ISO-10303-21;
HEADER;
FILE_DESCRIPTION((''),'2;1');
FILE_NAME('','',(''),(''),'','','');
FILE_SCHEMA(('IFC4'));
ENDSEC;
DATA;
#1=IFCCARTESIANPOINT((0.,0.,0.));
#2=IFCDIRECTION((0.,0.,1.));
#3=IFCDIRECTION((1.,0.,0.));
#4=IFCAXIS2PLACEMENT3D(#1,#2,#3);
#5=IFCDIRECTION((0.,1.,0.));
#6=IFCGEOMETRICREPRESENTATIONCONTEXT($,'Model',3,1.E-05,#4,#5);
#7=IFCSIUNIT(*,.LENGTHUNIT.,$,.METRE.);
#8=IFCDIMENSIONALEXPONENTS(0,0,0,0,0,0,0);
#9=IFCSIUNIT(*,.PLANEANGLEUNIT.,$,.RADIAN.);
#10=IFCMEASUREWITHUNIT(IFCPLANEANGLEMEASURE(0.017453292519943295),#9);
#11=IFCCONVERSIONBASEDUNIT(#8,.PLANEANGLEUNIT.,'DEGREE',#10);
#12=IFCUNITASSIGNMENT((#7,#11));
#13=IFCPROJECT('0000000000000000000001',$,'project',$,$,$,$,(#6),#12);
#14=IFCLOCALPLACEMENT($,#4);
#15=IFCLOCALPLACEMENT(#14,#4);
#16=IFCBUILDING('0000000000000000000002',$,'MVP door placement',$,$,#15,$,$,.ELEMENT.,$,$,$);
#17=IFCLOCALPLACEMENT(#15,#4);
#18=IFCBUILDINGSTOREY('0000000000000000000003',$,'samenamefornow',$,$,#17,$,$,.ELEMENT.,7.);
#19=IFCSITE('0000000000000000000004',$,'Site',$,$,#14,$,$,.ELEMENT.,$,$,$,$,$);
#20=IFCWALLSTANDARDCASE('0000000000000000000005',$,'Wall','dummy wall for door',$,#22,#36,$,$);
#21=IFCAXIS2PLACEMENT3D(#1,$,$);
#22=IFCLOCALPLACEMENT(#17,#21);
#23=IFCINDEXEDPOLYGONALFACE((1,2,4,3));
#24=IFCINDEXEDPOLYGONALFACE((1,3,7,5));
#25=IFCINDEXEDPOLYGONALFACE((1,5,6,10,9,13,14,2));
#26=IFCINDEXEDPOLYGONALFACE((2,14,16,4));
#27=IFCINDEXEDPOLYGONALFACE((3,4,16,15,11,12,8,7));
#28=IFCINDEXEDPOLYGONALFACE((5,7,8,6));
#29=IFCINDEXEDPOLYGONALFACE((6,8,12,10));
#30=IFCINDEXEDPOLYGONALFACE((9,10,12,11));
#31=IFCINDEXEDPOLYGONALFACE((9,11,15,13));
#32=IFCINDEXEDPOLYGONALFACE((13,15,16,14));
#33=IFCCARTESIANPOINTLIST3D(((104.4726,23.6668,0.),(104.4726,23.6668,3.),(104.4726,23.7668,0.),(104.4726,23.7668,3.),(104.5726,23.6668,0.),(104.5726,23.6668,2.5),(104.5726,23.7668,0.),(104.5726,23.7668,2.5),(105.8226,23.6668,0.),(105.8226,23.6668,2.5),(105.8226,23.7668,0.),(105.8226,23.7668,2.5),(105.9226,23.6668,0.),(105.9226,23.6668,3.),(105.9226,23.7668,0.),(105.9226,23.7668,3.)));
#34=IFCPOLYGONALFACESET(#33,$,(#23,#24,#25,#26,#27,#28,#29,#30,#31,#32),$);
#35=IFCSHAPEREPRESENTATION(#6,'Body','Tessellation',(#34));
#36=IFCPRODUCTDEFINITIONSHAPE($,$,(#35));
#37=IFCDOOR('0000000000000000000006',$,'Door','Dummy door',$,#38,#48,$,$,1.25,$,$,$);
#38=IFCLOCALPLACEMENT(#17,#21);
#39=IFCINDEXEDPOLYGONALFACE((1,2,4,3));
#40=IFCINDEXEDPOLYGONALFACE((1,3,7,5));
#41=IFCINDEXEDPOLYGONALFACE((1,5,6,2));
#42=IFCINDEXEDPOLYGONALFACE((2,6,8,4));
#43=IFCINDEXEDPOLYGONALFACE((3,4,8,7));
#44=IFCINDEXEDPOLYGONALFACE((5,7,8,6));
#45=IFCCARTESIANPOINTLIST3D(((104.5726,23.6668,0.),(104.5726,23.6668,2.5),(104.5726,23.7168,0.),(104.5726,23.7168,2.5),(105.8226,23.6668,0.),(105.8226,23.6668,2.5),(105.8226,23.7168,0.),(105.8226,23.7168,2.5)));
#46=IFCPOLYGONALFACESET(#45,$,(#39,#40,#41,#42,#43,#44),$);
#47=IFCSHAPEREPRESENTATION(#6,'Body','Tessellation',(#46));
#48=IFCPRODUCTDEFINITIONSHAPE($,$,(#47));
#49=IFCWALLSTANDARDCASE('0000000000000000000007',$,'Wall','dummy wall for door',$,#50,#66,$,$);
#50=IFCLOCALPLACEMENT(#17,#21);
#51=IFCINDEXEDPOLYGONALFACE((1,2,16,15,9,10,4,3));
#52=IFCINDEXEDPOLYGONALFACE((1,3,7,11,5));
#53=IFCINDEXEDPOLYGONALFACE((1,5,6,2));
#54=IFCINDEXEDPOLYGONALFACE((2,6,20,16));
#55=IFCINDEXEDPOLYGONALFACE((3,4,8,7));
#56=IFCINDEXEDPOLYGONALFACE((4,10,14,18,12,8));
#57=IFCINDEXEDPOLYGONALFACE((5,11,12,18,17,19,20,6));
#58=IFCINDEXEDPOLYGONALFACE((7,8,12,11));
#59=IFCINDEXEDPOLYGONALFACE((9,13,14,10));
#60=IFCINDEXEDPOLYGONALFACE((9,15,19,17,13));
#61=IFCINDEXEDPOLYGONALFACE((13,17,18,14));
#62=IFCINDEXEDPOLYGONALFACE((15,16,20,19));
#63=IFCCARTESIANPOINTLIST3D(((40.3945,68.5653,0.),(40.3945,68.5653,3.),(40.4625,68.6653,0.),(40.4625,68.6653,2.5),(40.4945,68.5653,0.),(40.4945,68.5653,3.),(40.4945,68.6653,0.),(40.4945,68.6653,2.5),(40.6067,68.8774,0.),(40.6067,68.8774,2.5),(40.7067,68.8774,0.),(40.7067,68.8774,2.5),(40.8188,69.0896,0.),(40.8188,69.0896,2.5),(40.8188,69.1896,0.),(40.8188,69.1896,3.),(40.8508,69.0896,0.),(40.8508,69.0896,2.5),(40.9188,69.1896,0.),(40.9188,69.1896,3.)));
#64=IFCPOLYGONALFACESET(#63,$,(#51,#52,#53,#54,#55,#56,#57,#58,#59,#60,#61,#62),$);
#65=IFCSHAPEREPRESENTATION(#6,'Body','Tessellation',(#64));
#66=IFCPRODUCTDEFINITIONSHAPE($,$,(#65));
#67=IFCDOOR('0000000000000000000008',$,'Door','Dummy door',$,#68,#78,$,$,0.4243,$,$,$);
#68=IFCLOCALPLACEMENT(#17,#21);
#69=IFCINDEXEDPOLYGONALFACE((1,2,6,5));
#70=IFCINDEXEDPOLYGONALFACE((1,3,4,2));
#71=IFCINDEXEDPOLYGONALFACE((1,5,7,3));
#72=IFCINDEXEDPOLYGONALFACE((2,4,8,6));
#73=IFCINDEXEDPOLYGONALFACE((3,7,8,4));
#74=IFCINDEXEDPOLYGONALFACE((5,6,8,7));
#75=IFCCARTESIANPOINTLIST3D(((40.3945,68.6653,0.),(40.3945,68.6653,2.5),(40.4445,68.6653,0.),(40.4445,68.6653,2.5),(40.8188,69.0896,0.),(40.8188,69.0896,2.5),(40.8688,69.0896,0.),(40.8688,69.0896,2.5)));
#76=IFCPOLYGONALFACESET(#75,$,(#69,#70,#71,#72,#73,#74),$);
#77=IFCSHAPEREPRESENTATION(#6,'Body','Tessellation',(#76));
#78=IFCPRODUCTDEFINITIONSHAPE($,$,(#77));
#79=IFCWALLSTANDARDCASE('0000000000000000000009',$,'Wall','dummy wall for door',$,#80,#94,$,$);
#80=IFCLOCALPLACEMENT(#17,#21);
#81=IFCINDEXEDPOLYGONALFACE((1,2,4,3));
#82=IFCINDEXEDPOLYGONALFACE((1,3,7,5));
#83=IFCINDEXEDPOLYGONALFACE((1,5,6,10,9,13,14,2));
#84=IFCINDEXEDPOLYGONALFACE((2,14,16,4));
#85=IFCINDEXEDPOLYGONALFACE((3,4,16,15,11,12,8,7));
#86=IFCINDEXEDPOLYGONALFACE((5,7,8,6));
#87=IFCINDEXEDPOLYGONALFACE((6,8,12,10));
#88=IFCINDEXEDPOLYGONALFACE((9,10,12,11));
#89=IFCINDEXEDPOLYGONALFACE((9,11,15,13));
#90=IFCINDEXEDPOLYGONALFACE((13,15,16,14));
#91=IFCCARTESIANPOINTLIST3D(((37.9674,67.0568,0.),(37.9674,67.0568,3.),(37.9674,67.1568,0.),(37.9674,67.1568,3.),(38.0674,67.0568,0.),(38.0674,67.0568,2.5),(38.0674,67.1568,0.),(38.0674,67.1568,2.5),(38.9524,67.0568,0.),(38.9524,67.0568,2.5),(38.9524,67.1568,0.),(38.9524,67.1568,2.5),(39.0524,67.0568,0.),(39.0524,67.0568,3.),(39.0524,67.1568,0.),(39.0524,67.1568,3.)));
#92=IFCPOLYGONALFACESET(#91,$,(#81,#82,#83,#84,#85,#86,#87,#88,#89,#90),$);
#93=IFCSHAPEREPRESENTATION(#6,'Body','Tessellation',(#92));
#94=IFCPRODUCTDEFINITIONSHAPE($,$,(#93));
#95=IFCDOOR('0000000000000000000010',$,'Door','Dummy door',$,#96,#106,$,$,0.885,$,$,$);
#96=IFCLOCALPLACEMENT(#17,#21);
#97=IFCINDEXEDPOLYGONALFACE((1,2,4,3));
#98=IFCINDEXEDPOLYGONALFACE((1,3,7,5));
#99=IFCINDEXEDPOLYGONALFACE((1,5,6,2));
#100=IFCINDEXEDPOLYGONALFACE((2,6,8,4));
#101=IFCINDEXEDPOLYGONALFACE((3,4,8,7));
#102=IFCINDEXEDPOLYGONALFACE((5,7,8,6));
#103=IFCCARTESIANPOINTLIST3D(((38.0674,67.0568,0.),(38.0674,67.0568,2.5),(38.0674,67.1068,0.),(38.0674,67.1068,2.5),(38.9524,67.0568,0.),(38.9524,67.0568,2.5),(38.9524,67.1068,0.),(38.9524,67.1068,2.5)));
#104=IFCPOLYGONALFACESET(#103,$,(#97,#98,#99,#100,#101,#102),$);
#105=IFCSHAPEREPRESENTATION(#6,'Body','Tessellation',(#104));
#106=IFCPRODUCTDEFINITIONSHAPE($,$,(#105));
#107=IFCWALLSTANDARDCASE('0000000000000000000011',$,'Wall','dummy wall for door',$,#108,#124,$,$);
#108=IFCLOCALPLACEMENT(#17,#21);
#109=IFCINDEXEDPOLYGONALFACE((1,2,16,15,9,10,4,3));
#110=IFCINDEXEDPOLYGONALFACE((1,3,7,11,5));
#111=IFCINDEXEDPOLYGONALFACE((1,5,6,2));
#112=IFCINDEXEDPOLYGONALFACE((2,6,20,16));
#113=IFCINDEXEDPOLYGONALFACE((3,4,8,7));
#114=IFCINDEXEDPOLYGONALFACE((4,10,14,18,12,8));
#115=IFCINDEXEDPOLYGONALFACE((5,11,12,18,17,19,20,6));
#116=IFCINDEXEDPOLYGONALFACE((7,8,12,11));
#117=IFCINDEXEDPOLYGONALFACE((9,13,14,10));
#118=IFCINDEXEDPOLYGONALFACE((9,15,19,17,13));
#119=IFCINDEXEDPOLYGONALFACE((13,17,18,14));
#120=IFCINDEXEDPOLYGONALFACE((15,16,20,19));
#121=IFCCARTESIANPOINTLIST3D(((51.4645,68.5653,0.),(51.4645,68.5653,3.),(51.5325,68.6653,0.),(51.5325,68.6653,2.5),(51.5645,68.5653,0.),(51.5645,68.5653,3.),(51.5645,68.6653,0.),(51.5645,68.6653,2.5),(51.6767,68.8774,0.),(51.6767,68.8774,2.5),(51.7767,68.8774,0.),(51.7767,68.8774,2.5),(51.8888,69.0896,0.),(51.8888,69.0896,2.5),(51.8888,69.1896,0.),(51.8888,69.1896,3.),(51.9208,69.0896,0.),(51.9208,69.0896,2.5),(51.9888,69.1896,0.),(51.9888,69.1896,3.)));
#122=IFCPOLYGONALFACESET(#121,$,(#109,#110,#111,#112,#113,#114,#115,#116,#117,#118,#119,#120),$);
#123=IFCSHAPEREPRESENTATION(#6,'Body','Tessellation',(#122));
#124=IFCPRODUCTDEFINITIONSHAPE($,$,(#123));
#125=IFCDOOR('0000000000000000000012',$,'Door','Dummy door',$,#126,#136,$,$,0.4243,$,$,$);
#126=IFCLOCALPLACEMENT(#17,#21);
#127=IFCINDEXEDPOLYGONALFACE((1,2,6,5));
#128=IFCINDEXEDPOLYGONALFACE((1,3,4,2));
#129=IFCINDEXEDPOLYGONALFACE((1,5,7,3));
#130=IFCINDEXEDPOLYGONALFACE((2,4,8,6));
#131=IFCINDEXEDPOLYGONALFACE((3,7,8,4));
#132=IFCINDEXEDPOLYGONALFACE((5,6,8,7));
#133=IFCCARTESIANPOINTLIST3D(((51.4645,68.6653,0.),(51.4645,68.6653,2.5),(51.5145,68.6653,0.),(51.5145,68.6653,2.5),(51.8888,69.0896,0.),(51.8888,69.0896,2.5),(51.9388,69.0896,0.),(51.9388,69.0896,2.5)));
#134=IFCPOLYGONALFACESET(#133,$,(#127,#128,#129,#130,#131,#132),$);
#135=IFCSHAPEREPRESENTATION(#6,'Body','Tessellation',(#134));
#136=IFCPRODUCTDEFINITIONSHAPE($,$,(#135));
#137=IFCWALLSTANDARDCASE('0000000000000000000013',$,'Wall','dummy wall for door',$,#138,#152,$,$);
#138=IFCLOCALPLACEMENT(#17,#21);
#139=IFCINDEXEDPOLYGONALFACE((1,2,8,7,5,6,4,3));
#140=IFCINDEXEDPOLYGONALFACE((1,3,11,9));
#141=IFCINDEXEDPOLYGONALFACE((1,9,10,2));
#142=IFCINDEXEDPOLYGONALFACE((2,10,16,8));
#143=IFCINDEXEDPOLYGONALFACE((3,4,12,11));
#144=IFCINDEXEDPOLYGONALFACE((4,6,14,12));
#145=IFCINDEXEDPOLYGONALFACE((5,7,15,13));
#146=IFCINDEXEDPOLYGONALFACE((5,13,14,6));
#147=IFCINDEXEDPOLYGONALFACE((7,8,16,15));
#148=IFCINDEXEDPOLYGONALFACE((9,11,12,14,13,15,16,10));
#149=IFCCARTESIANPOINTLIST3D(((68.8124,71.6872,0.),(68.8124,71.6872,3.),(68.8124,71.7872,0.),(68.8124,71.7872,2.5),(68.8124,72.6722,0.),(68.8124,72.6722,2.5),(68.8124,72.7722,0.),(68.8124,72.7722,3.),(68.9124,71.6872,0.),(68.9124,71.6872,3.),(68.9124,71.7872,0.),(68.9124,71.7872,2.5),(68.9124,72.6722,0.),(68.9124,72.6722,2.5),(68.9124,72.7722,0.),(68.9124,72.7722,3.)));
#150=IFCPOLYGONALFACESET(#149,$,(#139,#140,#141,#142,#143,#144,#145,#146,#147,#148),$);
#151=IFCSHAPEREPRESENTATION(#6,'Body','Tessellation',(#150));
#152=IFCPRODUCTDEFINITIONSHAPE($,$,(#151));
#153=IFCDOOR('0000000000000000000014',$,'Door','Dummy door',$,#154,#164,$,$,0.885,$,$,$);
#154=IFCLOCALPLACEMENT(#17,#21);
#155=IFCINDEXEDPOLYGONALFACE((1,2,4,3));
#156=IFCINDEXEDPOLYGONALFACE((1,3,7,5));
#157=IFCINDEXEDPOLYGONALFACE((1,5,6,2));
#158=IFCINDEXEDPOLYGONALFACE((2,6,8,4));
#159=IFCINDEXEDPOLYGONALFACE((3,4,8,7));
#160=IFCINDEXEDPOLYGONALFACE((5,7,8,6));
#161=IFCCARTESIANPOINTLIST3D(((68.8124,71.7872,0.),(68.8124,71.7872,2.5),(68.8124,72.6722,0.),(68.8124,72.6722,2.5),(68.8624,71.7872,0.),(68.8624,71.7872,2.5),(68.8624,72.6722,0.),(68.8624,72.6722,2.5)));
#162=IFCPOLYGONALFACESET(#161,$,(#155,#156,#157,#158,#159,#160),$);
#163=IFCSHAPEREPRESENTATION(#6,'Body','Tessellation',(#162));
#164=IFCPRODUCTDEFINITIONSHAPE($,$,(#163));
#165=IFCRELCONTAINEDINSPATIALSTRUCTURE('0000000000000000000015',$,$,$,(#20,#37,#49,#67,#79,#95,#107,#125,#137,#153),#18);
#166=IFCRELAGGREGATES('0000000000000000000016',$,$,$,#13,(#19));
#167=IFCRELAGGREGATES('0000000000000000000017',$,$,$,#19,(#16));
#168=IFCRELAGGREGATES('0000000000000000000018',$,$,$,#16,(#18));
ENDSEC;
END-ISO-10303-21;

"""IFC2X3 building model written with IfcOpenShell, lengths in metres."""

from ifc_helpers import new_model, entity, si_unit, converted_unit, direction, origin_with_axes, place, context, project, spatial, polyline, outline, extrude, element, fill, save


model = new_model("IFC2X3")

# Units and contexts
model_context = context("Model", 3, precision=1e-05, world=origin_with_axes(), true_north=direction((0.0, 1.0, 0.0)))
ifc_project = project(units=[si_unit("LENGTHUNIT", "METRE"), converted_unit("PLANEANGLEUNIT", "DEGREE", entity("IfcPlaneAngleMeasure", 0.017453292519943295), si_unit("PLANEANGLEUNIT", "RADIAN"), dimensions=[0, 0, 0, 0, 0, 0, 0])], contexts=[model_context])

# Site, building, storey
site_placement = place(None, origin_with_axes())
site = spatial("IfcSite", under=ifc_project, at=site_placement, Name="Site", CompositionType="ELEMENT")
building_placement = place(site_placement, origin_with_axes())
building = spatial("IfcBuilding", under=site, at=building_placement, Name="MVP door placement", CompositionType="ELEMENT")
storey_placement = place(building_placement, origin_with_axes())
storey = spatial("IfcBuildingStorey", under=building, at=storey_placement, Name="samenamefornow", CompositionType="ELEMENT", Elevation=7.0)

# Walls, openings, doors
wall_1_placement = place(storey_placement, origin_with_axes())
wall_1 = element("IfcWallStandardCase", 1, at=wall_1_placement, inside=storey, Name="Wall", Description="dummy wall for door", context=model_context, shape_type="SweptSolid", body=[
    extrude(outline(polyline([(104.4726, 23.6668, 0.0), (105.9226, 23.6668, 0.0), (105.9226, 23.7668, 0.0), (104.4726, 23.7668, 0.0), (104.4726, 23.6668, 0.0)])), origin_with_axes(), (0.0, 0.0, 1.0), 3.0),
])
opening_1_placement = place(wall_1_placement, origin_with_axes())
opening_1 = element("IfcOpeningElement", 2, at=opening_1_placement, cuts=wall_1, context=model_context, shape_type="SweptSolid", body=[
    extrude(outline(polyline([(104.5726, 23.6668, 0.0), (105.8226, 23.6668, 0.0), (105.8226, 23.7668, 0.0), (104.5726, 23.7668, 0.0), (104.5726, 23.6668, 0.0)])), origin_with_axes(), (0.0, 0.0, 1.0), 2.5),
])
door_1_placement = place(opening_1_placement, origin_with_axes())
door_1 = element("IfcDoor", 3, at=door_1_placement, inside=storey, Name="Door", Description="Dummy door", OverallWidth=1.25, context=model_context, shape_type="SweptSolid", body=[
    extrude(outline(polyline([(104.5726, 23.6668, 0.0), (105.8226, 23.6668, 0.0), (105.8226, 23.7168, 0.0), (104.5726, 23.7168, 0.0), (104.5726, 23.6668, 0.0)])), origin_with_axes(), (0.0, 0.0, 1.0), 2.5),
])
fill(opening_1, door_1)
wall_2_placement = place(storey_placement, origin_with_axes())
wall_2 = element("IfcWallStandardCase", 4, at=wall_2_placement, inside=storey, Name="Wall", Description="dummy wall for door", context=model_context, shape_type="SweptSolid", body=[
    extrude(outline(polyline([(40.8188, 69.1896, 0.0), (40.3945, 68.5653, 0.0), (40.4945, 68.5653, 0.0), (40.9188, 69.1896, 0.0), (40.8188, 69.1896, 0.0)])), origin_with_axes(), (0.0, 0.0, 1.0), 3.0),
])
opening_2_placement = place(wall_2_placement, origin_with_axes())
opening_2 = element("IfcOpeningElement", 5, at=opening_2_placement, cuts=wall_2, context=model_context, shape_type="SweptSolid", body=[
    extrude(outline(polyline([(40.8188, 69.0896, 0.0), (40.3945, 68.6653, 0.0), (40.4945, 68.6653, 0.0), (40.9188, 69.0896, 0.0), (40.8188, 69.0896, 0.0)])), origin_with_axes(), (0.0, 0.0, 1.0), 2.5),
])
door_2_placement = place(opening_2_placement, origin_with_axes())
door_2 = element("IfcDoor", 6, at=door_2_placement, inside=storey, Name="Door", Description="Dummy door", OverallWidth=0.4243, context=model_context, shape_type="SweptSolid", body=[
    extrude(outline(polyline([(40.8188, 69.0896, 0.0), (40.3945, 68.6653, 0.0), (40.4445, 68.6653, 0.0), (40.8688, 69.0896, 0.0), (40.8188, 69.0896, 0.0)])), origin_with_axes(), (0.0, 0.0, 1.0), 2.5),
])
fill(opening_2, door_2)
wall_3_placement = place(storey_placement, origin_with_axes())
wall_3 = element("IfcWallStandardCase", 7, at=wall_3_placement, inside=storey, Name="Wall", Description="dummy wall for door", context=model_context, shape_type="SweptSolid", body=[
    extrude(outline(polyline([(37.9674, 67.0568, 0.0), (39.0524, 67.0568, 0.0), (39.0524, 67.1568, 0.0), (37.9674, 67.1568, 0.0), (37.9674, 67.0568, 0.0)])), origin_with_axes(), (0.0, 0.0, 1.0), 3.0),
])
opening_3_placement = place(wall_3_placement, origin_with_axes())
opening_3 = element("IfcOpeningElement", 8, at=opening_3_placement, cuts=wall_3, context=model_context, shape_type="SweptSolid", body=[
    extrude(outline(polyline([(38.0674, 67.0568, 0.0), (38.9524, 67.0568, 0.0), (38.9524, 67.1568, 0.0), (38.0674, 67.1568, 0.0), (38.0674, 67.0568, 0.0)])), origin_with_axes(), (0.0, 0.0, 1.0), 2.5),
])
door_3_placement = place(opening_3_placement, origin_with_axes())
door_3 = element("IfcDoor", 9, at=door_3_placement, inside=storey, Name="Door", Description="Dummy door", OverallWidth=0.885, context=model_context, shape_type="SweptSolid", body=[
    extrude(outline(polyline([(38.0674, 67.0568, 0.0), (38.9524, 67.0568, 0.0), (38.9524, 67.1068, 0.0), (38.0674, 67.1068, 0.0), (38.0674, 67.0568, 0.0)])), origin_with_axes(), (0.0, 0.0, 1.0), 2.5),
])
fill(opening_3, door_3)
wall_4_placement = place(storey_placement, origin_with_axes())
wall_4 = element("IfcWallStandardCase", 10, at=wall_4_placement, inside=storey, Name="Wall", Description="dummy wall for door", context=model_context, shape_type="SweptSolid", body=[
    extrude(outline(polyline([(51.8888, 69.1896, 0.0), (51.4645, 68.5653, 0.0), (51.5645, 68.5653, 0.0), (51.9888, 69.1896, 0.0), (51.8888, 69.1896, 0.0)])), origin_with_axes(), (0.0, 0.0, 1.0), 3.0),
])
opening_4_placement = place(wall_4_placement, origin_with_axes())
opening_4 = element("IfcOpeningElement", 11, at=opening_4_placement, cuts=wall_4, context=model_context, shape_type="SweptSolid", body=[
    extrude(outline(polyline([(51.8888, 69.0896, 0.0), (51.4645, 68.6653, 0.0), (51.5645, 68.6653, 0.0), (51.9888, 69.0896, 0.0), (51.8888, 69.0896, 0.0)])), origin_with_axes(), (0.0, 0.0, 1.0), 2.5),
])
door_4_placement = place(opening_4_placement, origin_with_axes())
door_4 = element("IfcDoor", 12, at=door_4_placement, inside=storey, Name="Door", Description="Dummy door", OverallWidth=0.4243, context=model_context, shape_type="SweptSolid", body=[
    extrude(outline(polyline([(51.8888, 69.0896, 0.0), (51.4645, 68.6653, 0.0), (51.5145, 68.6653, 0.0), (51.9388, 69.0896, 0.0), (51.8888, 69.0896, 0.0)])), origin_with_axes(), (0.0, 0.0, 1.0), 2.5),
])
fill(opening_4, door_4)
wall_5_placement = place(storey_placement, origin_with_axes())
wall_5 = element("IfcWallStandardCase", 13, at=wall_5_placement, inside=storey, Name="Wall", Description="dummy wall for door", context=model_context, shape_type="SweptSolid", body=[
    extrude(outline(polyline([(68.8124, 71.6872, 0.0), (68.8124, 72.7722, 0.0), (68.9124, 72.7722, 0.0), (68.9124, 71.6872, 0.0), (68.8124, 71.6872, 0.0)])), origin_with_axes(), (0.0, 0.0, 1.0), 3.0),
])
opening_5_placement = place(wall_5_placement, origin_with_axes())
opening_5 = element("IfcOpeningElement", 14, at=opening_5_placement, cuts=wall_5, context=model_context, shape_type="SweptSolid", body=[
    extrude(outline(polyline([(68.8124, 71.7872, 0.0), (68.8124, 72.6722, 0.0), (68.9124, 72.6722, 0.0), (68.9124, 71.7872, 0.0), (68.8124, 71.7872, 0.0)])), origin_with_axes(), (0.0, 0.0, 1.0), 2.5),
])
door_5_placement = place(opening_5_placement, origin_with_axes())
door_5 = element("IfcDoor", 15, at=door_5_placement, inside=storey, Name="Door", Description="Dummy door", OverallWidth=0.885, context=model_context, shape_type="SweptSolid", body=[
    extrude(outline(polyline([(68.8124, 71.7872, 0.0), (68.8124, 72.6722, 0.0), (68.8624, 72.6722, 0.0), (68.8624, 71.7872, 0.0), (68.8124, 71.7872, 0.0)])), origin_with_axes(), (0.0, 0.0, 1.0), 2.5),
])
fill(opening_5, door_5)

save(model, "model.ifc")
